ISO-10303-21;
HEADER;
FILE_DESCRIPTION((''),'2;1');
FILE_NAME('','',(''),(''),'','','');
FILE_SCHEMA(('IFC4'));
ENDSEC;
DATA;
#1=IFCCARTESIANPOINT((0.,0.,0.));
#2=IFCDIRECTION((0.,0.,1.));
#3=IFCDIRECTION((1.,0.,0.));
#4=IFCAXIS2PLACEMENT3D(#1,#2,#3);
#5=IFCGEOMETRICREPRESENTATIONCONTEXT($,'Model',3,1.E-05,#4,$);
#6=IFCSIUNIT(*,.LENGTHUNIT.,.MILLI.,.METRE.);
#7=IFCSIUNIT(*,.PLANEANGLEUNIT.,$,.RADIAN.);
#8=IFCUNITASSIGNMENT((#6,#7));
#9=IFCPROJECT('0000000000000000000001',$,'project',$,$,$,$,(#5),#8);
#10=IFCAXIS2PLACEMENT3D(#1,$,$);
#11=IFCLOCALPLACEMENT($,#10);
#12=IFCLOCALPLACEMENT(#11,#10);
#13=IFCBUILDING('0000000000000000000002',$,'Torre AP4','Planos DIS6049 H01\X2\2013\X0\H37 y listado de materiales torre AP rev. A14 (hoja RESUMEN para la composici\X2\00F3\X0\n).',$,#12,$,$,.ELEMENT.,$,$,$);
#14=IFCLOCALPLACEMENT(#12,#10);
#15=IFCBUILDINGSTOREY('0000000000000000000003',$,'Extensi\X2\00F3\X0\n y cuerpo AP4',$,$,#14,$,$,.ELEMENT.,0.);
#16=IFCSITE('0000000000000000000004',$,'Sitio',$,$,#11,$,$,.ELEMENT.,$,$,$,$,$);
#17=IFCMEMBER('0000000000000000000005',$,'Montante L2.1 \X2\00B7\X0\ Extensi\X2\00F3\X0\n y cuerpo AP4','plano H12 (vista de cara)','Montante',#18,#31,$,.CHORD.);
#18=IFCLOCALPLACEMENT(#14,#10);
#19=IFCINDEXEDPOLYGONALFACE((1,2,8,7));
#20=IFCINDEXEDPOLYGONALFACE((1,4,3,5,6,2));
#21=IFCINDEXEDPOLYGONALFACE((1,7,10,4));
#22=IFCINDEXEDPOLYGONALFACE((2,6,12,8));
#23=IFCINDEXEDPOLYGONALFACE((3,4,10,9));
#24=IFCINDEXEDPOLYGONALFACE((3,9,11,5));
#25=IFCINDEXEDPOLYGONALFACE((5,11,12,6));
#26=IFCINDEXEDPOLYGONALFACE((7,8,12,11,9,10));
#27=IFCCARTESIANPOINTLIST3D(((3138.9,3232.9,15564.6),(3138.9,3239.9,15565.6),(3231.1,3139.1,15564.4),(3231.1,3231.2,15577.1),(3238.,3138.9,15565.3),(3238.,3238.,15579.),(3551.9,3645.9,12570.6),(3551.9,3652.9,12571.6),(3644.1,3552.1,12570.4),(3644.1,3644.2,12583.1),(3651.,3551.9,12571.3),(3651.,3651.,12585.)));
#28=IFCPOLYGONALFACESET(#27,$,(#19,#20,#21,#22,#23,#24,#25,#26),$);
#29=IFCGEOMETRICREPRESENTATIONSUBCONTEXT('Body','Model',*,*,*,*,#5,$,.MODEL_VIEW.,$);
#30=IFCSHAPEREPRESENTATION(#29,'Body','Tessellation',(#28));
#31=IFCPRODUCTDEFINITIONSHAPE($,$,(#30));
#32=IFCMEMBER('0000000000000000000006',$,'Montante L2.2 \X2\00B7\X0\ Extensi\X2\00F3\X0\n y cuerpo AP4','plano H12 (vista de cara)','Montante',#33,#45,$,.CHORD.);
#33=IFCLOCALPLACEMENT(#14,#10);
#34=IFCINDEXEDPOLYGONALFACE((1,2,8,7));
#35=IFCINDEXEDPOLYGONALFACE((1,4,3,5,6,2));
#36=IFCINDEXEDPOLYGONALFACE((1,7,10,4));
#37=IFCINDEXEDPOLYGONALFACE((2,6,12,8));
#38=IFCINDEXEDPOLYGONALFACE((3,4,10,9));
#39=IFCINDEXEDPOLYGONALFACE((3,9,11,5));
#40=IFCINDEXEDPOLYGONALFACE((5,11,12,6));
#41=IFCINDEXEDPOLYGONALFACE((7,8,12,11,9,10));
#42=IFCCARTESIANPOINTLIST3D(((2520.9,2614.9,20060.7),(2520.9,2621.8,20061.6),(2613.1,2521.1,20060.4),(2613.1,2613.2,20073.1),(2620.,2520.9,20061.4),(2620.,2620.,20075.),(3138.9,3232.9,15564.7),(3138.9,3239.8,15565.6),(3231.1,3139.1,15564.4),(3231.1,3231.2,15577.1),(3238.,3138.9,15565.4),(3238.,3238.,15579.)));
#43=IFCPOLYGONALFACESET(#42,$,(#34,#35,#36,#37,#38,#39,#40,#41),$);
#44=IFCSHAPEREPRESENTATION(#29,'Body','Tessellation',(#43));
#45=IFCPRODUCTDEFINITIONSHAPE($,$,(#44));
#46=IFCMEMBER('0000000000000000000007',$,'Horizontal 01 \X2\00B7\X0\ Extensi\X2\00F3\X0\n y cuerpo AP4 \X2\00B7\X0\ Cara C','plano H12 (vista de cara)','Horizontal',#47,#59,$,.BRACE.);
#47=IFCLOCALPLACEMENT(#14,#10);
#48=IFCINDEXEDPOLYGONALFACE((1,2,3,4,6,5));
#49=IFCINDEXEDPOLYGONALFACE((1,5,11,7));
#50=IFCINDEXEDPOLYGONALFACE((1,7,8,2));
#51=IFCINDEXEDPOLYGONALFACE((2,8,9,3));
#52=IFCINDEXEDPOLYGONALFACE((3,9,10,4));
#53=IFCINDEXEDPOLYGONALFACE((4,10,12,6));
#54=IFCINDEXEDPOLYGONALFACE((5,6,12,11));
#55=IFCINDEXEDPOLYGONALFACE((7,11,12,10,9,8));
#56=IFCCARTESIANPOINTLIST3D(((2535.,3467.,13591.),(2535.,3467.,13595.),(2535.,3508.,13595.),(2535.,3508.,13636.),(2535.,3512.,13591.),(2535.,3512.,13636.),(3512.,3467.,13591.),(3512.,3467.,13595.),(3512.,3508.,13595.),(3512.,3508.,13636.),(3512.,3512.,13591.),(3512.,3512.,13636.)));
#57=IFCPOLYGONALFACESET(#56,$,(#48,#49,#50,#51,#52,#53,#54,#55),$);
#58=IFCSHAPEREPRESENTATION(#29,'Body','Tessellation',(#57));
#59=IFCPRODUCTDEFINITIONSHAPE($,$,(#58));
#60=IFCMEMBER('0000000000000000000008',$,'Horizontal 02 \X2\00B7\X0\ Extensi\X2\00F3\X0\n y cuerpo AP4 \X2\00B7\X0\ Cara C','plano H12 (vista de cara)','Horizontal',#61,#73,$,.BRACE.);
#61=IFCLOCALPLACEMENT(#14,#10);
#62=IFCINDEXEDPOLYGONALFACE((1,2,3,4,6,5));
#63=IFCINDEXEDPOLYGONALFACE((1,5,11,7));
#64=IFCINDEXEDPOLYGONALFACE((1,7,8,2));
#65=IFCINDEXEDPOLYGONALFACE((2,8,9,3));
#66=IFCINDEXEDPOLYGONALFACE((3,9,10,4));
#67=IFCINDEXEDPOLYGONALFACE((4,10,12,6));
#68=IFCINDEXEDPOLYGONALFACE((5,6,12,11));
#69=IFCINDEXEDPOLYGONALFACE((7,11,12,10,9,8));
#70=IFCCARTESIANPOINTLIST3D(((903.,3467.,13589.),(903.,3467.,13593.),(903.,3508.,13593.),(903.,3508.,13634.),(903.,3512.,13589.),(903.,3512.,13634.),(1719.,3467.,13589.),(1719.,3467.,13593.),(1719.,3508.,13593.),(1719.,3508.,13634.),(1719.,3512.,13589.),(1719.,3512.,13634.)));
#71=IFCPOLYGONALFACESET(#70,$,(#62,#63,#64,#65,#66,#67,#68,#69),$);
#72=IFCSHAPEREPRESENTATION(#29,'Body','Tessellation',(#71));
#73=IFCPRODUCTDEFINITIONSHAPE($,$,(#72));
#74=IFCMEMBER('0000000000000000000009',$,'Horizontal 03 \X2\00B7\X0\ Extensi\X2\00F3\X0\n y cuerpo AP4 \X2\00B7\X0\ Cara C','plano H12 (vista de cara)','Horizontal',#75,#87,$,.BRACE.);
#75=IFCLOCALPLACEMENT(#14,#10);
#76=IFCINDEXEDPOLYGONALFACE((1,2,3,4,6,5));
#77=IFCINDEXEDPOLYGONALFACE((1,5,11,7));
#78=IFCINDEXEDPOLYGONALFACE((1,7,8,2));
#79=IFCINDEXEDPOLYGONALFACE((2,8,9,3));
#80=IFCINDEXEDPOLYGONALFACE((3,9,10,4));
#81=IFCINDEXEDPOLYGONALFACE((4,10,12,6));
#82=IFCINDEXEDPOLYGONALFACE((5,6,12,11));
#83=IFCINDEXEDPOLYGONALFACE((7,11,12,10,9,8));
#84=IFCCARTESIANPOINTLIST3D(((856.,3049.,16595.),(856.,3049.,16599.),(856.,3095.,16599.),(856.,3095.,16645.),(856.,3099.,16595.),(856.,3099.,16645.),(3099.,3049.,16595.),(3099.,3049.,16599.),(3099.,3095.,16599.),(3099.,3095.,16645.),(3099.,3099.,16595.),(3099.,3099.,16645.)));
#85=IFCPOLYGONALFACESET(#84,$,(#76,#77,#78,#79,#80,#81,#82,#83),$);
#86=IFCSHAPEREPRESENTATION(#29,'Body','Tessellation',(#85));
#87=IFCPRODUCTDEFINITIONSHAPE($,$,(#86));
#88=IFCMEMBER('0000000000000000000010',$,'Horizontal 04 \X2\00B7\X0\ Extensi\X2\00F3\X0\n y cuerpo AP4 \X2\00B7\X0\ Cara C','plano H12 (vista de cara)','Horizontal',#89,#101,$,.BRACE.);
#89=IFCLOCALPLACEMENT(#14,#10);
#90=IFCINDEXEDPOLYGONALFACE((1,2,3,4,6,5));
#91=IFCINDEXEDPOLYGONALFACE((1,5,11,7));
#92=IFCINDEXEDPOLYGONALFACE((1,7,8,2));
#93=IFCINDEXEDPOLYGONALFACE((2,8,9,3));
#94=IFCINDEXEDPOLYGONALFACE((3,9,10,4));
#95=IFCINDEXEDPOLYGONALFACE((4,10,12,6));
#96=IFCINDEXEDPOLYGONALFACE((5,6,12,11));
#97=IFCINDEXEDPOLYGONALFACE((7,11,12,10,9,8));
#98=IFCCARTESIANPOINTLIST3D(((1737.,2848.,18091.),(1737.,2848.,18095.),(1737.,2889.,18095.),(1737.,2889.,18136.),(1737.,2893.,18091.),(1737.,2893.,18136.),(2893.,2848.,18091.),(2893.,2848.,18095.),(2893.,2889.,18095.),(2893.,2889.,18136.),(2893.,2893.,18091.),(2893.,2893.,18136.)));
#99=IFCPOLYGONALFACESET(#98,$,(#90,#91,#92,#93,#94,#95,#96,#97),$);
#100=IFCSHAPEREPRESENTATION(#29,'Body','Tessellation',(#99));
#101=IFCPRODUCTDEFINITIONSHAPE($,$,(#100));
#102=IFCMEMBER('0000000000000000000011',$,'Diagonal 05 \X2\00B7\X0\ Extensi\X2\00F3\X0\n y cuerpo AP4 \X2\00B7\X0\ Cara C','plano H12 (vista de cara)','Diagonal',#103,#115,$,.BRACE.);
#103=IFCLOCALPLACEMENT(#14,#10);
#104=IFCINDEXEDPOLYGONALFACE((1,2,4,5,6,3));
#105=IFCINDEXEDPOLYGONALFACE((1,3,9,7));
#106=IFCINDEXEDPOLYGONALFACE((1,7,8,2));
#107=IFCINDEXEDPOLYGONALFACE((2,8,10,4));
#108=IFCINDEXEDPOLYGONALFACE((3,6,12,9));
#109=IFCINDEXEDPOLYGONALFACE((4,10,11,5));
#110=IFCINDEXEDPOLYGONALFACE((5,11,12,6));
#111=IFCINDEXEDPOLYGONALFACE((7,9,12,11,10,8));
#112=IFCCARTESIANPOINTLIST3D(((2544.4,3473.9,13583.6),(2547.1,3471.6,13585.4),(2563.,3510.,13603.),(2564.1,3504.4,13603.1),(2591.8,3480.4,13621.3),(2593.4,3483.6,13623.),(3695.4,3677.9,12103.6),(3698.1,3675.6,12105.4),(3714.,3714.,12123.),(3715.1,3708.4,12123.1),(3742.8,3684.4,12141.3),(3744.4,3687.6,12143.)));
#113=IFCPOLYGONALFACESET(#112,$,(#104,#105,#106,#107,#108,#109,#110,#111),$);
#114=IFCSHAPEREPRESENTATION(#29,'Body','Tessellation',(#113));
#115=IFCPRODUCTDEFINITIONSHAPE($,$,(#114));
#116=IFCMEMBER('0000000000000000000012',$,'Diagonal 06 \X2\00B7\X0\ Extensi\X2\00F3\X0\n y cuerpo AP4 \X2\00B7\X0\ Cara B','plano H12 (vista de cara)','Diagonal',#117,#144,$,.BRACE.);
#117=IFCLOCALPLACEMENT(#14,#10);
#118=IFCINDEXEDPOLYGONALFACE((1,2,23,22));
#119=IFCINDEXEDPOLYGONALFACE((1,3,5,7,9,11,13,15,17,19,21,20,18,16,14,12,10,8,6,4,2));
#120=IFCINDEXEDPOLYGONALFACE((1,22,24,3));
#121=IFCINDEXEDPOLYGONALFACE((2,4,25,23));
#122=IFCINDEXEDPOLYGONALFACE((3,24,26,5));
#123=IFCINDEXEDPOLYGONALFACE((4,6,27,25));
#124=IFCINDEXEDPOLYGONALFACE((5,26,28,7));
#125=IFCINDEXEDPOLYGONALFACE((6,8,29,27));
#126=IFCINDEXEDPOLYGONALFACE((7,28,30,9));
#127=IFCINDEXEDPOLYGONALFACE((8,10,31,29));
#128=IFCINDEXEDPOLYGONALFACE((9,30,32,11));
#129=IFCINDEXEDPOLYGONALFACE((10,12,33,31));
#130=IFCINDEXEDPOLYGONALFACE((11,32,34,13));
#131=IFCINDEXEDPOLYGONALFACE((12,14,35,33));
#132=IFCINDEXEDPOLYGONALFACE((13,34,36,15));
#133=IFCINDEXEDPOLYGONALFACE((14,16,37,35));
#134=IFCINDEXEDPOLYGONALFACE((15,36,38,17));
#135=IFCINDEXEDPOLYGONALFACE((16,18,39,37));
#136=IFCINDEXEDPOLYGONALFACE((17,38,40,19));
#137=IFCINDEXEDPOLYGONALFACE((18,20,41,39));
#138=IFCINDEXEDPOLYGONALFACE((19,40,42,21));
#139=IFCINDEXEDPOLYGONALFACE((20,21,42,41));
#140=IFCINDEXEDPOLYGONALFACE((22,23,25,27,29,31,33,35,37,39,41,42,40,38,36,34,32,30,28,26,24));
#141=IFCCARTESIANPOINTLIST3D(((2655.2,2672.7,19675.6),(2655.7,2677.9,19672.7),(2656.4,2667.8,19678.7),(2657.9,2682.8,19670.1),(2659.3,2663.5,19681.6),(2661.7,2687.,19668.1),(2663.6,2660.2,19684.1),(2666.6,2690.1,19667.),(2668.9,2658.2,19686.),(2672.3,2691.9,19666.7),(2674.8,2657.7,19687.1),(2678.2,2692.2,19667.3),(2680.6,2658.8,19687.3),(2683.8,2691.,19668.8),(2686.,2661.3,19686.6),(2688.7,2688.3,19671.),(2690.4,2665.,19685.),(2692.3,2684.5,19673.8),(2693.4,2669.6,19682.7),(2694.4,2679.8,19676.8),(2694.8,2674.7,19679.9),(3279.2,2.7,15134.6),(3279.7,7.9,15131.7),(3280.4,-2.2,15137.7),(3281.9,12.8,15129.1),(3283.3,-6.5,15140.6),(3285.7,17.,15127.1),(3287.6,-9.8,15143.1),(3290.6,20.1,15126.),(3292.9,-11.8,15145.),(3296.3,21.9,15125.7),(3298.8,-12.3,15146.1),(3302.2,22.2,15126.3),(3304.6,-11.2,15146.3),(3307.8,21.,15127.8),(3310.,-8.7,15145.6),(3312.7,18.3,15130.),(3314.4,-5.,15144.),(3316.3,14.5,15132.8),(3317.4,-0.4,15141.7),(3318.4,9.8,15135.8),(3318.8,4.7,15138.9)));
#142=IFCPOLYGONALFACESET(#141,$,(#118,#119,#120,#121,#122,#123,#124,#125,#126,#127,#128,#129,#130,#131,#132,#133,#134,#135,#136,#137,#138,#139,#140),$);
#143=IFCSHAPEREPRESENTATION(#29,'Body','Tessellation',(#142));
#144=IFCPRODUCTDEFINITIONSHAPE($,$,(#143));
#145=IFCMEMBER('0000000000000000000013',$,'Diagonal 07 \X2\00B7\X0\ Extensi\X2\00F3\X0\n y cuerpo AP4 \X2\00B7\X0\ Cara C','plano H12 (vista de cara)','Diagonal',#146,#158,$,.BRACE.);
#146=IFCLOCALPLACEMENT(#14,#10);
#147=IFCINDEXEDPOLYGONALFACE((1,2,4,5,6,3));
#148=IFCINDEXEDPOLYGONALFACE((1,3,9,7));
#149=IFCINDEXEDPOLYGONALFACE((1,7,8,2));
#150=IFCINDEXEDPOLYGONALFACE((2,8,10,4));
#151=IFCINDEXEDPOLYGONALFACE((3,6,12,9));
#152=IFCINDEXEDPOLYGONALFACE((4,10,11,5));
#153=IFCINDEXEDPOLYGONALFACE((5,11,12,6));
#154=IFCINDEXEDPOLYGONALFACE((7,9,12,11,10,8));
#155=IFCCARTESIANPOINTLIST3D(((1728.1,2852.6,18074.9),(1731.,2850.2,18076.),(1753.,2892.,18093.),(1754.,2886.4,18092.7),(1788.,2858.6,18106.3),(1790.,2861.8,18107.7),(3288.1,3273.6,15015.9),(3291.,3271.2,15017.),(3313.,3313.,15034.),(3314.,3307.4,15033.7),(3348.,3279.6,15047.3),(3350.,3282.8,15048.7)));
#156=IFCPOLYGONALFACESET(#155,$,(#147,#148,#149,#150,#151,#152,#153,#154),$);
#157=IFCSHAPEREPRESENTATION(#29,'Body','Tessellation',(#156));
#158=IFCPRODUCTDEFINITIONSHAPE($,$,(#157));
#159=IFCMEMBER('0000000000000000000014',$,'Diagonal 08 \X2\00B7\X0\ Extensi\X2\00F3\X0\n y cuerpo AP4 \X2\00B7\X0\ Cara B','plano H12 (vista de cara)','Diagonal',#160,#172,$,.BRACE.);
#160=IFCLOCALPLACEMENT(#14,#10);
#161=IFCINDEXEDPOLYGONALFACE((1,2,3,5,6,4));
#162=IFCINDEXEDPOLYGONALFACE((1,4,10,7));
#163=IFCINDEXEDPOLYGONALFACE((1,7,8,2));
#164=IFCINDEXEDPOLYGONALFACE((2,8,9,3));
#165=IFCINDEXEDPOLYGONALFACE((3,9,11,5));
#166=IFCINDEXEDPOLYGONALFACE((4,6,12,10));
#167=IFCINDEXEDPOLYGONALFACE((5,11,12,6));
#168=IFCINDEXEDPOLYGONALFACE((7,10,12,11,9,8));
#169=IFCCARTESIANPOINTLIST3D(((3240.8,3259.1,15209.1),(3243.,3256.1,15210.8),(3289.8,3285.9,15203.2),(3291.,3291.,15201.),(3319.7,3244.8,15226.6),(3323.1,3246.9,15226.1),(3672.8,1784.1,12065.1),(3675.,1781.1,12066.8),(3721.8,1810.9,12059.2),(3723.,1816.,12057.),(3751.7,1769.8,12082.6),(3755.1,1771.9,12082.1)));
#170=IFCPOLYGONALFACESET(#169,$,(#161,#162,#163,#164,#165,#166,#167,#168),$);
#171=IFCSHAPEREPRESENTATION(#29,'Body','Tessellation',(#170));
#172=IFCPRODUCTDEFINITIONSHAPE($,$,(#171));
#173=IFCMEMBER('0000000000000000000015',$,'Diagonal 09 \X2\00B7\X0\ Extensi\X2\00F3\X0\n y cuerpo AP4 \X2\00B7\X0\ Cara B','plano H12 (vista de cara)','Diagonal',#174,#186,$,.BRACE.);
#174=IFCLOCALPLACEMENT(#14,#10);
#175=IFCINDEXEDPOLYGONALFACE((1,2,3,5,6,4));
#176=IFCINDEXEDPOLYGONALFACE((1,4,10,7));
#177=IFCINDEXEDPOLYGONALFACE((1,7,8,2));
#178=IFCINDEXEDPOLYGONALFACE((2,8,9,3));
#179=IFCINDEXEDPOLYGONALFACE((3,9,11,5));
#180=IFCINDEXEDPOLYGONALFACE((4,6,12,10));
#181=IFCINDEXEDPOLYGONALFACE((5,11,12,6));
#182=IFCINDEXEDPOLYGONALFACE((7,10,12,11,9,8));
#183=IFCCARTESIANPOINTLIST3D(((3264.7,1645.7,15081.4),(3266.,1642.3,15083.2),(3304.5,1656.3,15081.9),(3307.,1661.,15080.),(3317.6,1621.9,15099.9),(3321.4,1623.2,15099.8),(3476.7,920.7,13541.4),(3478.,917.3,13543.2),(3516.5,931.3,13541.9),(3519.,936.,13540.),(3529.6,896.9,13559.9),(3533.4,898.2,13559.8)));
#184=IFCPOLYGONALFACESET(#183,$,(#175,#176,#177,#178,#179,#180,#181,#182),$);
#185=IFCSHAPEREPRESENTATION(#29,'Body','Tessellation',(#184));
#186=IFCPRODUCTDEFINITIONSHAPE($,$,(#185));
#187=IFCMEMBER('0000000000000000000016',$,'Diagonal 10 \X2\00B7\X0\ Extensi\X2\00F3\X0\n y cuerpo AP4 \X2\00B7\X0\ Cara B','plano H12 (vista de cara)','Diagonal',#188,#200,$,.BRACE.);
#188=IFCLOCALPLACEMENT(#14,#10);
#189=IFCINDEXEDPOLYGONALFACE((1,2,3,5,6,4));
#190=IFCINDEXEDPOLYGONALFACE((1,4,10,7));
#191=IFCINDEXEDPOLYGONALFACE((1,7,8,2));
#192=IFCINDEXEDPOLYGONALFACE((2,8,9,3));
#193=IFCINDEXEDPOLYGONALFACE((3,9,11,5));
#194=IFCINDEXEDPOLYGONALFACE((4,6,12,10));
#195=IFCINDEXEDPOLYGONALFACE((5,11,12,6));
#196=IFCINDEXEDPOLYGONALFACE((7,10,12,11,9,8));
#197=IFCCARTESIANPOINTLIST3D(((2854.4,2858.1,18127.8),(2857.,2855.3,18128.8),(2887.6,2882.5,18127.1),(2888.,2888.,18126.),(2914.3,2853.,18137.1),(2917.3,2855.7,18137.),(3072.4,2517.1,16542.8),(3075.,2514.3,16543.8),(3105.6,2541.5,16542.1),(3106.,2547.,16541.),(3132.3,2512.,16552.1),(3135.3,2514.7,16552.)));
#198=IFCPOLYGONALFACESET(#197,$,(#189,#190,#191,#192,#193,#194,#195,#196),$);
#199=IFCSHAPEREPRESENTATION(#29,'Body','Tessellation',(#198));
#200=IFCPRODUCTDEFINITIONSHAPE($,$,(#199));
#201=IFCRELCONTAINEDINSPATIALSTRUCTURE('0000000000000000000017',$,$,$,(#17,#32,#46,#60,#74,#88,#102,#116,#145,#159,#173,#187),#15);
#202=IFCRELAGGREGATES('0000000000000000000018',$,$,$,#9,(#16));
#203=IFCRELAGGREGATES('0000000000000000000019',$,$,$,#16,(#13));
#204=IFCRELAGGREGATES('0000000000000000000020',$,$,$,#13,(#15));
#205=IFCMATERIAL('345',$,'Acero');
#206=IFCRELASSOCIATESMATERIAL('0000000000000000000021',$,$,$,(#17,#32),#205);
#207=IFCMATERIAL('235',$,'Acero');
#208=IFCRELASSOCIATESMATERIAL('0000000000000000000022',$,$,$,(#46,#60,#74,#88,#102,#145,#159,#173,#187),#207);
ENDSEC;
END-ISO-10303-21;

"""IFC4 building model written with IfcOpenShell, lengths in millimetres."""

from ifc_helpers import new_model, si_unit, frame, frame_2d, origin, origin_with_axes, place, context, subcontext, project, spatial, circle, l_section, extrude, material, element, save


model = new_model("IFC4")

# Units and contexts
model_context = context("Model", 3, precision=1e-05, world=origin_with_axes())
body_context = subcontext(model_context, "Body", "Model", "MODEL_VIEW")
ifc_project = project(units=[si_unit("LENGTHUNIT", "METRE", prefix="MILLI"), si_unit("PLANEANGLEUNIT", "RADIAN")], contexts=[model_context])

# Site, building, storey
site_placement = place(None, origin())
site = spatial("IfcSite", under=ifc_project, at=site_placement, Name="Sitio", CompositionType="ELEMENT")
building_placement = place(site_placement, origin())
building = spatial("IfcBuilding", under=site, at=building_placement, Name="Torre AP4", Description="Planos DIS6049 H01–H37 y listado de materiales torre AP rev. A14 (hoja RESUMEN para la composición).", CompositionType="ELEMENT")
storey_placement = place(building_placement, origin())
storey = spatial("IfcBuildingStorey", under=building, at=storey_placement, Name="Extensión y cuerpo AP4", CompositionType="ELEMENT", Elevation=0.0)

# Members
ifc_material_1 = material(Name="345", Category="Acero")
member_1_placement = place(storey_placement, frame((3651.0, 3651.0, 12585.0), z_axis=(-0.13539, -0.13539, 0.981498), x_axis=(-0.990792, 0.018501, -0.13412)))
element("IfcMember", 1, at=member_1_placement, inside=storey, material=ifc_material_1, Name="Montante L2.1 · Extensión y cuerpo AP4", Description="plano H12 (vista de cara)", ObjectType="Montante", PredefinedType="CHORD", context=body_context, shape_type="SweptSolid", body=[
    extrude(l_section(Depth=100.0, Width=100.0, Thickness=7.0, at=frame_2d((50.0, 50.0))), None, (0.0, 0.0, 1.0), 3050.4),
])
member_2_placement = place(storey_placement, frame((3238.0, 3238.0, 15579.0), z_axis=(-0.13493, -0.13493, 0.981625), x_axis=(-0.990855, 0.018374, -0.133673)))
element("IfcMember", 2, at=member_2_placement, inside=storey, material=ifc_material_1, Name="Montante L2.2 · Extensión y cuerpo AP4", Description="plano H12 (vista de cara)", ObjectType="Montante", PredefinedType="CHORD", context=body_context, shape_type="SweptSolid", body=[
    extrude(l_section(Depth=100.0, Width=100.0, Thickness=7.0, at=frame_2d((50.0, 50.0))), None, (0.0, 0.0, 1.0), 4580.2),
])
ifc_material_2 = material(Name="235", Category="Acero")
member_3_placement = place(storey_placement, frame((3512.0, 3512.0, 13591.0), z_axis=(-1.0, 0.0, 0.0), x_axis=(0.0, -1.0, 0.0)))
element("IfcMember", 3, at=member_3_placement, inside=storey, material=ifc_material_2, Name="Horizontal 01 · Extensión y cuerpo AP4 · Cara C", Description="plano H12 (vista de cara)", ObjectType="Horizontal", PredefinedType="BRACE", context=body_context, shape_type="SweptSolid", body=[
    extrude(l_section(Depth=45.0, Width=45.0, Thickness=4.0, at=frame_2d((22.5, 22.5))), None, (0.0, 0.0, 1.0), 977.0),
])
member_4_placement = place(storey_placement, frame((1719.0, 3512.0, 13589.0), z_axis=(-1.0, 0.0, 0.0), x_axis=(0.0, -1.0, 0.0)))
element("IfcMember", 4, at=member_4_placement, inside=storey, material=ifc_material_2, Name="Horizontal 02 · Extensión y cuerpo AP4 · Cara C", Description="plano H12 (vista de cara)", ObjectType="Horizontal", PredefinedType="BRACE", context=body_context, shape_type="SweptSolid", body=[
    extrude(l_section(Depth=45.0, Width=45.0, Thickness=4.0, at=frame_2d((22.5, 22.5))), None, (0.0, 0.0, 1.0), 816.0),
])
member_5_placement = place(storey_placement, frame((3099.0, 3099.0, 16595.0), z_axis=(-1.0, 0.0, 0.0), x_axis=(0.0, -1.0, 0.0)))
element("IfcMember", 5, at=member_5_placement, inside=storey, material=ifc_material_2, Name="Horizontal 03 · Extensión y cuerpo AP4 · Cara C", Description="plano H12 (vista de cara)", ObjectType="Horizontal", PredefinedType="BRACE", context=body_context, shape_type="SweptSolid", body=[
    extrude(l_section(Depth=50.0, Width=50.0, Thickness=4.0, at=frame_2d((25.0, 25.0))), None, (0.0, 0.0, 1.0), 2243.0),
])
member_6_placement = place(storey_placement, frame((2893.0, 2893.0, 18091.0), z_axis=(-1.0, 0.0, 0.0), x_axis=(0.0, -1.0, 0.0)))
element("IfcMember", 6, at=member_6_placement, inside=storey, material=ifc_material_2, Name="Horizontal 04 · Extensión y cuerpo AP4 · Cara C", Description="plano H12 (vista de cara)", ObjectType="Horizontal", PredefinedType="BRACE", context=body_context, shape_type="SweptSolid", body=[
    extrude(l_section(Depth=45.0, Width=45.0, Thickness=4.0, at=frame_2d((22.5, 22.5))), None, (0.0, 0.0, 1.0), 1156.0),
])
member_7_placement = place(storey_placement, frame((3714.0, 3714.0, 12123.0), z_axis=(-0.610302, -0.108168, 0.784749), x_axis=(-0.412878, -0.802007, -0.431644)))
element("IfcMember", 7, at=member_7_placement, inside=storey, material=ifc_material_2, Name="Diagonal 05 · Extensión y cuerpo AP4 · Cara C", Description="plano H12 (vista de cara)", ObjectType="Diagonal", PredefinedType="BRACE", context=body_context, shape_type="SweptSolid", body=[
    extrude(l_section(Depth=45.0, Width=45.0, Thickness=4.0, at=frame_2d((22.5, 22.5))), None, (0.0, 0.0, 1.0), 1886.0),
])
member_8_placement = place(storey_placement, frame((3299.0, 5.0, 15136.0), z_axis=(-0.117633, 0.503335, 0.856047), x_axis=(-0.928538, -0.361399, 0.0849)))
element("IfcMember", 8, at=member_8_placement, inside=storey, Name="Diagonal 06 · Extensión y cuerpo AP4 · Cara B", Description="plano H12 (vista de cara)", ObjectType="Diagonal", PredefinedType="BRACE", context=body_context, shape_type="SweptSolid", body=[
    extrude(circle(Radius=20.0), None, (0.0, 0.0, 1.0), 5304.6),
])
member_9_placement = place(storey_placement, frame((3313.0, 3313.0, 15034.0), z_axis=(-0.450929, -0.121693, 0.884225), x_axis=(-0.498615, -0.787324, -0.362636)))
element("IfcMember", 9, at=member_9_placement, inside=storey, material=ifc_material_2, Name="Diagonal 07 · Extensión y cuerpo AP4 · Cara C", Description="plano H12 (vista de cara)", ObjectType="Diagonal", PredefinedType="BRACE", context=body_context, shape_type="SweptSolid", body=[
    extrude(l_section(Depth=50.0, Width=50.0, Thickness=4.0, at=frame_2d((25.0, 25.0))), None, (0.0, 0.0, 1.0), 3459.5),
])
member_10_placement = place(storey_placement, frame((3723.0, 1816.0, 12057.0), z_axis=(-0.123444, 0.42148, 0.898396), x_axis=(-0.835962, -0.531995, 0.134719)))
element("IfcMember", 10, at=member_10_placement, inside=storey, material=ifc_material_2, Name="Diagonal 08 · Extensión y cuerpo AP4 · Cara B", Description="plano H12 (vista de cara)", ObjectType="Diagonal", PredefinedType="BRACE", context=body_context, shape_type="SweptSolid", body=[
    extrude(l_section(Depth=60.0, Width=60.0, Thickness=4.0, at=frame_2d((30.0, 30.0))), None, (0.0, 0.0, 1.0), 3499.6),
])
member_11_placement = place(storey_placement, frame((3519.0, 936.0, 13540.0), z_axis=(-0.123595, 0.422673, 0.897815), x_axis=(-0.939509, -0.341096, 0.031246)))
element("IfcMember", 11, at=member_11_placement, inside=storey, material=ifc_material_2, Name="Diagonal 09 · Extensión y cuerpo AP4 · Cara B", Description="plano H12 (vista de cara)", ObjectType="Diagonal", PredefinedType="BRACE", context=body_context, shape_type="SweptSolid", body=[
    extrude(l_section(Depth=45.0, Width=45.0, Thickness=4.0, at=frame_2d((22.5, 22.5))), None, (0.0, 0.0, 1.0), 1715.3),
])
member_12_placement = place(storey_placement, frame((3106.0, 2547.0, 16541.0), z_axis=(-0.133263, 0.208453, 0.968911), x_axis=(-0.746947, -0.663676, 0.04005)))
element("IfcMember", 12, at=member_12_placement, inside=storey, material=ifc_material_2, Name="Diagonal 10 · Extensión y cuerpo AP4 · Cara B", Description="plano H12 (vista de cara)", ObjectType="Diagonal", PredefinedType="BRACE", context=body_context, shape_type="SweptSolid", body=[
    extrude(l_section(Depth=45.0, Width=45.0, Thickness=4.0, at=frame_2d((22.5, 22.5))), None, (0.0, 0.0, 1.0), 1635.9),
])

save(model, "model.ifc")
